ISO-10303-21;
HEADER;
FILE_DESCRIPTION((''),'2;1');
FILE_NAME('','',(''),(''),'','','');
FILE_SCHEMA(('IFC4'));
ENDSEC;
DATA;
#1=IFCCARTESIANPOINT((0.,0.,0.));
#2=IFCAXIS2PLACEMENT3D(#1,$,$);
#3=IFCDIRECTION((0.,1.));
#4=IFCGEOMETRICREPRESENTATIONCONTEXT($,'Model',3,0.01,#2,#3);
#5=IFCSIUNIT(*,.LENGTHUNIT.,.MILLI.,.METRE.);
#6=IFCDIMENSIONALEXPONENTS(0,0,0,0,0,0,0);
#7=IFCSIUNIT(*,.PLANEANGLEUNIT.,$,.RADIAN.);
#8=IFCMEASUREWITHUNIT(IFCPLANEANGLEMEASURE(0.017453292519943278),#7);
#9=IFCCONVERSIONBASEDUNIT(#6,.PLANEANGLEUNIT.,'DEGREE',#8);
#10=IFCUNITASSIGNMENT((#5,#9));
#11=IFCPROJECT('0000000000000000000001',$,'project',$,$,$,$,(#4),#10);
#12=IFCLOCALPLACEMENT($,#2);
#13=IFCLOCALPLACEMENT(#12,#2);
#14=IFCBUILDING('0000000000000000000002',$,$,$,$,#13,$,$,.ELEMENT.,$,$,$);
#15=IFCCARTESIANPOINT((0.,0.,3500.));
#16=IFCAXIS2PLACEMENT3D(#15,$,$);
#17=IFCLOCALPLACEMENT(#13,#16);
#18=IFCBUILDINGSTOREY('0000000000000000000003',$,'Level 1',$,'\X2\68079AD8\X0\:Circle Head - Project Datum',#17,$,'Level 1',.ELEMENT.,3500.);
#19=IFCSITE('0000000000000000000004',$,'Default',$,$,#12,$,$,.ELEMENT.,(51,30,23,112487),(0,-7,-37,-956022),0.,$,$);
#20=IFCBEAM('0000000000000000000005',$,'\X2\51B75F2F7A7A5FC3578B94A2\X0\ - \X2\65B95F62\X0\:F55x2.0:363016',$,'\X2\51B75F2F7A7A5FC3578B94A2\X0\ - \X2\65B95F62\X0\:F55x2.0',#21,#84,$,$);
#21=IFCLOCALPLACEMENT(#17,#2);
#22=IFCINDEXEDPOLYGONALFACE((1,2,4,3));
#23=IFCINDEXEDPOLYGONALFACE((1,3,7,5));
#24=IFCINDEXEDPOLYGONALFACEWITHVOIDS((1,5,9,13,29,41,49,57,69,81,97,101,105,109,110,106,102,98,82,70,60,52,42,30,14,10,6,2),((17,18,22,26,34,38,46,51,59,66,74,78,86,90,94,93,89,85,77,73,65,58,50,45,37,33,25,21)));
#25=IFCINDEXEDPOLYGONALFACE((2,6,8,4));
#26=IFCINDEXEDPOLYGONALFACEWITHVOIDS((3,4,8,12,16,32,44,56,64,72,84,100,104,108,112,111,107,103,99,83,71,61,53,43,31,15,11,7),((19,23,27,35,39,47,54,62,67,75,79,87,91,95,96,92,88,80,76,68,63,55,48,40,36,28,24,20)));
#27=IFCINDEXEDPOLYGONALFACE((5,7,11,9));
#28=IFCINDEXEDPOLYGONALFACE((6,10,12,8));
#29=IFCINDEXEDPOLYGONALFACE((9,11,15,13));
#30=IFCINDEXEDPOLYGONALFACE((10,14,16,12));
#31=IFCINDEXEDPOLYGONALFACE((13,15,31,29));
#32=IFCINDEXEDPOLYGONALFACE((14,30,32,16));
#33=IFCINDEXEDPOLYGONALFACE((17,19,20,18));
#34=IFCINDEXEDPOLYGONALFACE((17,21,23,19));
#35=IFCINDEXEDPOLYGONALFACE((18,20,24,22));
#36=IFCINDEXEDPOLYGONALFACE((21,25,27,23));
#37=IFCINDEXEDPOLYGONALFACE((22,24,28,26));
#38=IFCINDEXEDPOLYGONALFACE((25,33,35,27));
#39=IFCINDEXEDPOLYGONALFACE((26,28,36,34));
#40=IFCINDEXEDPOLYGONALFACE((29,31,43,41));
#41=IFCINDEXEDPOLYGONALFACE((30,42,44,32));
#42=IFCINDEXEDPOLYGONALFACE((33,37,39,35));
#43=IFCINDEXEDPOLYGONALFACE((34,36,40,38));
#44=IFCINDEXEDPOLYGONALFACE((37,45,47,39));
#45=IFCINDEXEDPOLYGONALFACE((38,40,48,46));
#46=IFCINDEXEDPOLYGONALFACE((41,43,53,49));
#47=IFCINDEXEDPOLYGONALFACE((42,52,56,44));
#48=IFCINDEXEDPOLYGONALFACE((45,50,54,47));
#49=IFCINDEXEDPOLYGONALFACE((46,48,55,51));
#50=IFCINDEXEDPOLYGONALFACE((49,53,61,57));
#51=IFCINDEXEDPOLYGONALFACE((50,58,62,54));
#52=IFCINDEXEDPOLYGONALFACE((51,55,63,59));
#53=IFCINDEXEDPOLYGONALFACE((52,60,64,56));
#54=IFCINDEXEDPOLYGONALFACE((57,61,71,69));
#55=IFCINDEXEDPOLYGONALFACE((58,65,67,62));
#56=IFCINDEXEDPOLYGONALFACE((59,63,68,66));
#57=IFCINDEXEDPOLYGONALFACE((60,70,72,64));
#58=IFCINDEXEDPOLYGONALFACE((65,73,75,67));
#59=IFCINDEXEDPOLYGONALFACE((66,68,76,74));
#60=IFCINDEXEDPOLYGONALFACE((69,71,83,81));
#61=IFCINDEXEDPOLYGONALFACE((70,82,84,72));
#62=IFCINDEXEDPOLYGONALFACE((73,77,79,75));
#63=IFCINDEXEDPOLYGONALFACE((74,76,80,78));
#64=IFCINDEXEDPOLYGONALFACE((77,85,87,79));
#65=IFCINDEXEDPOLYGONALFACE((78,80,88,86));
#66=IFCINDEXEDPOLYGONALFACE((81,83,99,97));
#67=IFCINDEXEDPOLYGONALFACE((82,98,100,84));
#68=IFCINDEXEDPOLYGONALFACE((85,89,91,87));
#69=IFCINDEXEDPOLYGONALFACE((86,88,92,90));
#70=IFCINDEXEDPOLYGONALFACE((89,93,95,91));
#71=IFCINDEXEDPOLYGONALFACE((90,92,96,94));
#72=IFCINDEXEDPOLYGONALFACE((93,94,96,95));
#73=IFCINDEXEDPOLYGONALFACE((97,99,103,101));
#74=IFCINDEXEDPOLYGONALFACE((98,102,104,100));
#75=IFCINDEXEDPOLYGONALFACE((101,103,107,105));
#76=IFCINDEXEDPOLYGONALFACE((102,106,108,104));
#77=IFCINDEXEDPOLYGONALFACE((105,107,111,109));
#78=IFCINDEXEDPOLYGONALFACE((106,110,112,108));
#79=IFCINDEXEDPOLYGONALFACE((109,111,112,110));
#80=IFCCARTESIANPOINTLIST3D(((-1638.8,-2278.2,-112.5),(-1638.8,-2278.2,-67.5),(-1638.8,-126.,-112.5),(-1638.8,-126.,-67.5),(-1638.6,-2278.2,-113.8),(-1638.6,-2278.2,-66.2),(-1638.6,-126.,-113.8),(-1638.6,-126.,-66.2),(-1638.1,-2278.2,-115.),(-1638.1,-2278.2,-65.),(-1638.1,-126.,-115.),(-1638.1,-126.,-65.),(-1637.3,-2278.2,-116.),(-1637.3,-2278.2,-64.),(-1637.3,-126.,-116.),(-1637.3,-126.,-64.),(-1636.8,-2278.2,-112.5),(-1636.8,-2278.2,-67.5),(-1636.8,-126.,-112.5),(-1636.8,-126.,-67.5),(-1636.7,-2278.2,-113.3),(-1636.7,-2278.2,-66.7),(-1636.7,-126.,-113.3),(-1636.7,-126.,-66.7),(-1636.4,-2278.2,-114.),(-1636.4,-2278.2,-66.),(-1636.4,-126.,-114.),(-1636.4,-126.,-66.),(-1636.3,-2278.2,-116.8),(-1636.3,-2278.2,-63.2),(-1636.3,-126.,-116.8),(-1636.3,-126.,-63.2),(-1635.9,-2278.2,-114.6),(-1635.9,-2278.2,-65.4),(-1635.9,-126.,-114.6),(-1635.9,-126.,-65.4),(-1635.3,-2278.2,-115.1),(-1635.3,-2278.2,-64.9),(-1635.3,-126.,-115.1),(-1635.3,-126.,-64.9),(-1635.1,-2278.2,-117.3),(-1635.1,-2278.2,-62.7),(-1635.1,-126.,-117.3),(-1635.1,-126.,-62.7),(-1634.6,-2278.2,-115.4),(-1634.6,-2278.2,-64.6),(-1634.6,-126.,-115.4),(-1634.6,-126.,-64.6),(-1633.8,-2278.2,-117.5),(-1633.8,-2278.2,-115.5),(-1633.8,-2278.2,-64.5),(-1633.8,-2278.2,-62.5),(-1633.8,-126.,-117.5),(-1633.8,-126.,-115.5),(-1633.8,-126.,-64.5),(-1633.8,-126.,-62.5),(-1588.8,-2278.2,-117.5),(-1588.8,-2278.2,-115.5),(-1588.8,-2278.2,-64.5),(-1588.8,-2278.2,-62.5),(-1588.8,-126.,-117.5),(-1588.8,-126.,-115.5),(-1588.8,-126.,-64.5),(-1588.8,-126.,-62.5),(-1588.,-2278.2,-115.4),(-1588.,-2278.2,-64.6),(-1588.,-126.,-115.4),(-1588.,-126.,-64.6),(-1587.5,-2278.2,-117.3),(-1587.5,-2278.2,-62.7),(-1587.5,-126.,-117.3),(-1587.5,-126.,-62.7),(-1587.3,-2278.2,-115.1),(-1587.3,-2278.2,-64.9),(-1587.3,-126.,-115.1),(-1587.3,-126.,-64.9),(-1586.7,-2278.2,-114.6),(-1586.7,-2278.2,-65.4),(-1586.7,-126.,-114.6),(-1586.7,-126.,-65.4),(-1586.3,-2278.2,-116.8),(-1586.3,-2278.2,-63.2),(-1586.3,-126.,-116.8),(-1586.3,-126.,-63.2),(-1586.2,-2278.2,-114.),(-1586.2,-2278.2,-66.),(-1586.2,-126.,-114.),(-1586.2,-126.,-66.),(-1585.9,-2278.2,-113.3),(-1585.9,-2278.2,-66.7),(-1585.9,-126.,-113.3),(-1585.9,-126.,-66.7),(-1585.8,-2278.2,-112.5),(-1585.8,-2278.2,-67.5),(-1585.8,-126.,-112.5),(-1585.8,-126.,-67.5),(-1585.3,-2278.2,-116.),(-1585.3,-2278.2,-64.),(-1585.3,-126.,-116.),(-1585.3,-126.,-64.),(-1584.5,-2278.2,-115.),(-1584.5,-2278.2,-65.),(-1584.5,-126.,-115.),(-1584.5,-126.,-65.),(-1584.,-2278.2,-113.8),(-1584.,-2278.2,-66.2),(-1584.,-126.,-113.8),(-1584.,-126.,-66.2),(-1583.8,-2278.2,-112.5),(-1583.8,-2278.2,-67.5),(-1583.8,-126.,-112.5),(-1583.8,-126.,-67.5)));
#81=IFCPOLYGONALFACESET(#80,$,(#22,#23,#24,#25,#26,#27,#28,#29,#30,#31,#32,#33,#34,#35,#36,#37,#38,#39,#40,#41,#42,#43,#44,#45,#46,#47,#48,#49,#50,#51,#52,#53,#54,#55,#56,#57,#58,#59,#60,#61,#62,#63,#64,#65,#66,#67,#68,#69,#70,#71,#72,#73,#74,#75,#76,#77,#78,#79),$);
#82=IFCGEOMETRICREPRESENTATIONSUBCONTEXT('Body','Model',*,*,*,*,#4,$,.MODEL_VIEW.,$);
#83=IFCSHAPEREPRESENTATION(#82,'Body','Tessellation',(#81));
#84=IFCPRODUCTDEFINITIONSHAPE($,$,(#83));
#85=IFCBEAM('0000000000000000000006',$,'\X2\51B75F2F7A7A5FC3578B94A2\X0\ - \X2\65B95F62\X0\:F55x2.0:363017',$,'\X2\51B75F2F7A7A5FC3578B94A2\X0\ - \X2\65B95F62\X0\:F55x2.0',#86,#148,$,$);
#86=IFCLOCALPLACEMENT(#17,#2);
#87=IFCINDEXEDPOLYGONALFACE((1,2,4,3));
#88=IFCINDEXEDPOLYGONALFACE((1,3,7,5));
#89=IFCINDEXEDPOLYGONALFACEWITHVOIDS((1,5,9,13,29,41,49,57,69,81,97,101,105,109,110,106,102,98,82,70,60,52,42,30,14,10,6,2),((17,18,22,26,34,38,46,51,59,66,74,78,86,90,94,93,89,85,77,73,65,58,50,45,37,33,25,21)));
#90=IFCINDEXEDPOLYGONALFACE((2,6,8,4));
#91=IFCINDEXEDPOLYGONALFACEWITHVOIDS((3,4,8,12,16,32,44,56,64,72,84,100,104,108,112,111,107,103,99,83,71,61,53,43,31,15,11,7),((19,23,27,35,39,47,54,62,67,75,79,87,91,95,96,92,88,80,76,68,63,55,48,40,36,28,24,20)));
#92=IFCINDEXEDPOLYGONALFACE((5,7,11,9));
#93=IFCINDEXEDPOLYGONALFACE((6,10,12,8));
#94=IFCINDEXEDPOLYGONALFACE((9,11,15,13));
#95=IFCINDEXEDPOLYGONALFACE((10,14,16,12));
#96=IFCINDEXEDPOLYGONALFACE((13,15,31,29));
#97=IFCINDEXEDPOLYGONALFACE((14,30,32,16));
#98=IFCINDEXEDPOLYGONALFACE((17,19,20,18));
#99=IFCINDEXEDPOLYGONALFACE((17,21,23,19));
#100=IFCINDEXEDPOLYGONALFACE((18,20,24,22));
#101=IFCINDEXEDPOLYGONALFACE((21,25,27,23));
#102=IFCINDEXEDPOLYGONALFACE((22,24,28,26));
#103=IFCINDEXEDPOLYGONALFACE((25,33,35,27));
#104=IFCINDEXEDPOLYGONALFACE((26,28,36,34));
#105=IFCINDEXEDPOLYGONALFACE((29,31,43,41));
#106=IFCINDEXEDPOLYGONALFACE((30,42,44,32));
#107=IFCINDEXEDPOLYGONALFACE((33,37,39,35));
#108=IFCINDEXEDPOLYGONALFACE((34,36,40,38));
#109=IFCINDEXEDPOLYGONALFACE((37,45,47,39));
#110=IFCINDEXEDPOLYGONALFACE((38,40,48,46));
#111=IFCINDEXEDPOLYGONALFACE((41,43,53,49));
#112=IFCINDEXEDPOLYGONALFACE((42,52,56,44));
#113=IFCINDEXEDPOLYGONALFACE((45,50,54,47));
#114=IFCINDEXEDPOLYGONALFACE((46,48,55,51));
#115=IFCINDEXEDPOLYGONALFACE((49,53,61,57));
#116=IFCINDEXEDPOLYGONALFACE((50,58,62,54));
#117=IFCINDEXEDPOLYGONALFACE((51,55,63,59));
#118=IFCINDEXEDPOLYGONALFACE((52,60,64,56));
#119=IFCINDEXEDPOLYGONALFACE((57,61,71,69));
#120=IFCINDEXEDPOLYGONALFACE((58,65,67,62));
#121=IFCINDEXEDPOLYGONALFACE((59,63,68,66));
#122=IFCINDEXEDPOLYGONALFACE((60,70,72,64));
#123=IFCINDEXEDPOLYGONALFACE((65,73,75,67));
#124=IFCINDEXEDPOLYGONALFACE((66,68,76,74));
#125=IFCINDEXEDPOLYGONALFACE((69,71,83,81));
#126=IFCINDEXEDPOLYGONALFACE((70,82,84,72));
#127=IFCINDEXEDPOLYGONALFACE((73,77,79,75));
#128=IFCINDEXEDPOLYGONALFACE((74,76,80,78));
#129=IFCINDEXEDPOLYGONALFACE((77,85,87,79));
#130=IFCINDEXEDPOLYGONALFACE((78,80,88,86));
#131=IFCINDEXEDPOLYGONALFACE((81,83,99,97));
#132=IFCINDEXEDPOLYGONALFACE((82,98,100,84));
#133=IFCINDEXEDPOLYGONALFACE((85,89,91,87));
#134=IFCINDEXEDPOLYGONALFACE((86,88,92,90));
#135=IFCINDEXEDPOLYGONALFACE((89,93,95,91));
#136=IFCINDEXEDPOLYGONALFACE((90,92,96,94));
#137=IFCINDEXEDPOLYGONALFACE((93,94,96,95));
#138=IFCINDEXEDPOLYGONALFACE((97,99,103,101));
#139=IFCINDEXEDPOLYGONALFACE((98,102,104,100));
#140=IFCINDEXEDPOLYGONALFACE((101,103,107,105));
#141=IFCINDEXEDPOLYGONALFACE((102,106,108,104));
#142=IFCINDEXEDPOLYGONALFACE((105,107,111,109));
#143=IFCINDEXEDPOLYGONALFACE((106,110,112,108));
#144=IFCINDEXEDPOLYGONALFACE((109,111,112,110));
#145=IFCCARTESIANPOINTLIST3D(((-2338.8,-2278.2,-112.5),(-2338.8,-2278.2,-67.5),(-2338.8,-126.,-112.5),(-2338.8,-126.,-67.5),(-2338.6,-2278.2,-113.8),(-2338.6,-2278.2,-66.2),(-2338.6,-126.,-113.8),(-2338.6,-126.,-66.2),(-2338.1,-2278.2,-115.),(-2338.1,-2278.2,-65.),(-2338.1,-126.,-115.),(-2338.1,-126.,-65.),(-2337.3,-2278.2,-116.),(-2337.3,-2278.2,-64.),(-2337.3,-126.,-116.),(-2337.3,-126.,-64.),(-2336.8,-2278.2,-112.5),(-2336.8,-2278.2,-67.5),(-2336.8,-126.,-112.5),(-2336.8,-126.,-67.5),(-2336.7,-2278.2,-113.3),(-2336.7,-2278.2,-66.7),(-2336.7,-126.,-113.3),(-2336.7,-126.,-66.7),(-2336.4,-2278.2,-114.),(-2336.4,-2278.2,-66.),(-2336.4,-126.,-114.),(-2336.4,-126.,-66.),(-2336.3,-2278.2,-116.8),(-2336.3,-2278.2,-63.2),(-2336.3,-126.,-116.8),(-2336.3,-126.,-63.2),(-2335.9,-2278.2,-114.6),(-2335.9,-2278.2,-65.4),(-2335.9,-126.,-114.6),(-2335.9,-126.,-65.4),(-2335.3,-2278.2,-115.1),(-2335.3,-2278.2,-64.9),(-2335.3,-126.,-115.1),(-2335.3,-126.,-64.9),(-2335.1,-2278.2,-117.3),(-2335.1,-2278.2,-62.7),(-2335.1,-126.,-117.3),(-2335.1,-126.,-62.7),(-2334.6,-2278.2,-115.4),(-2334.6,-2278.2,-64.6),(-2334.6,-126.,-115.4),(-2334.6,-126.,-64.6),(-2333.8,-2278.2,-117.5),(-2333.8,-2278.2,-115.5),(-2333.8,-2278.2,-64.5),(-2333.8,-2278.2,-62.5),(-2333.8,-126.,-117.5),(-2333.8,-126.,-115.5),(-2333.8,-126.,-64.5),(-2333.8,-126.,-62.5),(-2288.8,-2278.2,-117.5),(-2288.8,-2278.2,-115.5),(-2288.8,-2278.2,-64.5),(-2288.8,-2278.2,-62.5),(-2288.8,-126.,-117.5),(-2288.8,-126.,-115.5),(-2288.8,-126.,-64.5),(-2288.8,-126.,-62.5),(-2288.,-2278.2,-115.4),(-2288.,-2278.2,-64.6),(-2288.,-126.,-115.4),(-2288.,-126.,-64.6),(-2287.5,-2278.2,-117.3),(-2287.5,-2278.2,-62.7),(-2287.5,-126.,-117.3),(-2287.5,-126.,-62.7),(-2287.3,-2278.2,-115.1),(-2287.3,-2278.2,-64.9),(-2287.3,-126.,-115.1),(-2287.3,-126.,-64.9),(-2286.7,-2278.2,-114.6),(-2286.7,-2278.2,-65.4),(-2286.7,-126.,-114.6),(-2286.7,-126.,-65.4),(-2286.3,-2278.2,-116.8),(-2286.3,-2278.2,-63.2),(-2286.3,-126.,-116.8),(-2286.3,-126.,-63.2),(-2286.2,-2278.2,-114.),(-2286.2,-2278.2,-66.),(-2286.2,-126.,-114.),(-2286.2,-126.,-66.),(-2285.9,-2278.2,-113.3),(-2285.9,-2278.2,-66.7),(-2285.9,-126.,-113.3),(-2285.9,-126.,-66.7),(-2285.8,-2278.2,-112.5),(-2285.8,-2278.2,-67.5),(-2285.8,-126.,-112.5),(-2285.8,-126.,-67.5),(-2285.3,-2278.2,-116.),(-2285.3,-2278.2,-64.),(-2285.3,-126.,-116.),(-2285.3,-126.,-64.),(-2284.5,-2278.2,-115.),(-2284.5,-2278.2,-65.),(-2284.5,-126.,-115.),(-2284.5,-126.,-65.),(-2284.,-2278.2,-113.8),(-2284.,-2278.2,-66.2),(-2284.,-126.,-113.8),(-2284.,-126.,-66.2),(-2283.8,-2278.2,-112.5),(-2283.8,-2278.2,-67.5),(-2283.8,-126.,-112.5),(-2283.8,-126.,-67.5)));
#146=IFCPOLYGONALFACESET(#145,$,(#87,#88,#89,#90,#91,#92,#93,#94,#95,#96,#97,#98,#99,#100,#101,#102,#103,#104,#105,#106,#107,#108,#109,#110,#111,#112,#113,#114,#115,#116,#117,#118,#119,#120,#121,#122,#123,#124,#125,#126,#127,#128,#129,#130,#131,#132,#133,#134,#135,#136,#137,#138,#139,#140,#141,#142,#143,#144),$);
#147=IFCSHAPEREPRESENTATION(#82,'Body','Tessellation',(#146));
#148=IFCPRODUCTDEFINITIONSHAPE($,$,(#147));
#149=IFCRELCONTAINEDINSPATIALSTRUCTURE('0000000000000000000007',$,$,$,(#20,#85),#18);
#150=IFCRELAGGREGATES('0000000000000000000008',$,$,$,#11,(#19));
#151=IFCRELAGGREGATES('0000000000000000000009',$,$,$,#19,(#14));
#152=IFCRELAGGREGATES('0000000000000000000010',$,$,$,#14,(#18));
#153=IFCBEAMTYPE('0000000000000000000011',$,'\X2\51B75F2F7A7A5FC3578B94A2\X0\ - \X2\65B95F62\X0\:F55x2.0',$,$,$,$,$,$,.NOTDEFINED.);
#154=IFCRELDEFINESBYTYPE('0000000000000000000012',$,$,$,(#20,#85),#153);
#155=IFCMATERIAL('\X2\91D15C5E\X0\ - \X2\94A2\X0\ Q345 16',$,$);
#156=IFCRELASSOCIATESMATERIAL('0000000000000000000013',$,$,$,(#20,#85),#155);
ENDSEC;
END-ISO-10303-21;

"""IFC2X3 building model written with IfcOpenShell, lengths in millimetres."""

from ifc_helpers import new_model, entity, si_unit, converted_unit, direction, frame, frame_2d, origin, place, context, subcontext, project, spatial, polyline, circle_curve, parameter, trimmed, segment, composite_curve, outline, extrude, material, type_object, element, save


model = new_model("IFC2X3")

# Units and contexts
model_context = context("Model", 3, precision=0.01, world=origin(), true_north=direction((0.0, 1.0)))
body_context = subcontext(model_context, "Body", "Model", "MODEL_VIEW")
ifc_project = project(units=[si_unit("LENGTHUNIT", "METRE", prefix="MILLI"), converted_unit("PLANEANGLEUNIT", "DEGREE", entity("IfcPlaneAngleMeasure", 0.017453292519943278), si_unit("PLANEANGLEUNIT", "RADIAN"), dimensions=[0, 0, 0, 0, 0, 0, 0])], contexts=[model_context])

# Site, building, storey
site_placement = place(None, origin())
site = spatial("IfcSite", under=ifc_project, at=site_placement, Name="Default", CompositionType="ELEMENT", RefLatitude=(51, 30, 23, 112487), RefLongitude=(0, -7, -37, -956022), RefElevation=0.0)
building_placement = place(site_placement, origin())
building = spatial("IfcBuilding", under=site, at=building_placement, CompositionType="ELEMENT")
storey_placement = place(building_placement, frame((0.0, 0.0, 3500.0)))
storey = spatial("IfcBuildingStorey", under=building, at=storey_placement, Name="Level 1", ObjectType="标高:Circle Head - Project Datum", LongName="Level 1", CompositionType="ELEMENT", Elevation=3500.0)

# Beams
ifc_material_1 = material(Name="金属 - 钢 Q345 16")
beam_type_1 = type_object("IfcBeamType", Name="冷弯空心型钢 - 方形:F55x2.0", PredefinedType="NOTDEFINED")
beam_1_placement = place(storey_placement, frame((-1611.3, -390.5, -62.5), z_axis=(0.0, 0.0, 1.0), x_axis=(0.0, -1.0, 0.0)))
element("IfcBeam", 1, at=beam_1_placement, inside=storey, type_object=beam_type_1, material=ifc_material_1, Name="冷弯空心型钢 - 方形:F55x2.0:363016", ObjectType="冷弯空心型钢 - 方形:F55x2.0", context=body_context, shape_type="SweptSolid", body=[
    extrude(outline(composite_curve([segment(trimmed(circle_curve(frame_2d((-22.5, 22.5), x_axis=(1.0, 0.0)), 5.0), [parameter(90.0)], [parameter(180.0)], True, "PARAMETER"), True, "CONTINUOUS"), segment(polyline([(-27.5, 22.5), (-27.5, -22.5)]), True, "CONTINUOUS"), segment(trimmed(circle_curve(frame_2d((-22.5, -22.5), x_axis=(1.0, 0.0)), 5.0), [parameter(180.0)], [parameter(270.0)], True, "PARAMETER"), True, "CONTINUOUS"), segment(polyline([(-22.5, -27.5), (22.5, -27.5)]), True, "CONTINUOUS"), segment(trimmed(circle_curve(frame_2d((22.5, -22.5), x_axis=(1.0, 0.0)), 5.0), [parameter(270.0)], [parameter(0.0)], True, "PARAMETER"), True, "CONTINUOUS"), segment(polyline([(27.5, -22.5), (27.5, 22.5)]), True, "CONTINUOUS"), segment(trimmed(circle_curve(frame_2d((22.5, 22.5), x_axis=(1.0, 0.0)), 5.0), [parameter(0.0)], [parameter(90.0)], True, "PARAMETER"), True, "CONTINUOUS"), segment(polyline([(22.5, 27.5), (-22.5, 27.5)]), True, "CONTINUOUS")], self_intersect=False), holes=[composite_curve([segment(polyline([(-22.5, 25.5), (22.5, 25.5)]), True, "CONTINUOUS"), segment(trimmed(circle_curve(frame_2d((22.5, 22.5), x_axis=(1.0, 0.0)), 3.0), [parameter(0.0)], [parameter(90.0)], True, "PARAMETER"), False, "CONTINUOUS"), segment(polyline([(25.5, 22.5), (25.5, -22.5)]), True, "CONTINUOUS"), segment(trimmed(circle_curve(frame_2d((22.5, -22.5), x_axis=(1.0, 0.0)), 3.0), [parameter(270.0)], [parameter(360.0)], True, "PARAMETER"), False, "CONTINUOUS"), segment(polyline([(22.5, -25.5), (-22.5, -25.5)]), True, "CONTINUOUS"), segment(trimmed(circle_curve(frame_2d((-22.5, -22.5), x_axis=(1.0, 0.0)), 3.0), [parameter(180.0)], [parameter(270.0)], True, "PARAMETER"), False, "CONTINUOUS"), segment(polyline([(-25.5, -22.5), (-25.5, 22.5)]), True, "CONTINUOUS"), segment(trimmed(circle_curve(frame_2d((-22.5, 22.5), x_axis=(1.0, 0.0)), 3.0), [parameter(90.0)], [parameter(180.0)], True, "PARAMETER"), False, "CONTINUOUS")], self_intersect=False)]), frame((-264.5, 0.0, -27.5), z_axis=(1.0, 0.0, 0.0), x_axis=(0.0, 1.0, 0.0)), (0.0, 0.0, 1.0), 2152.2),
])
beam_2_placement = place(storey_placement, frame((-2311.3, -390.5, -62.5), z_axis=(0.0, 0.0, 1.0), x_axis=(0.0, -1.0, 0.0)))
element("IfcBeam", 2, at=beam_2_placement, inside=storey, type_object=beam_type_1, material=ifc_material_1, Name="冷弯空心型钢 - 方形:F55x2.0:363017", ObjectType="冷弯空心型钢 - 方形:F55x2.0", context=body_context, shape_type="SweptSolid", body=[
    extrude(outline(composite_curve([segment(trimmed(circle_curve(frame_2d((-22.5, 22.5), x_axis=(1.0, 0.0)), 5.0), [parameter(90.0)], [parameter(180.0)], True, "PARAMETER"), True, "CONTINUOUS"), segment(polyline([(-27.5, 22.5), (-27.5, -22.5)]), True, "CONTINUOUS"), segment(trimmed(circle_curve(frame_2d((-22.5, -22.5), x_axis=(1.0, 0.0)), 5.0), [parameter(180.0)], [parameter(270.0)], True, "PARAMETER"), True, "CONTINUOUS"), segment(polyline([(-22.5, -27.5), (22.5, -27.5)]), True, "CONTINUOUS"), segment(trimmed(circle_curve(frame_2d((22.5, -22.5), x_axis=(1.0, 0.0)), 5.0), [parameter(270.0)], [parameter(0.0)], True, "PARAMETER"), True, "CONTINUOUS"), segment(polyline([(27.5, -22.5), (27.5, 22.5)]), True, "CONTINUOUS"), segment(trimmed(circle_curve(frame_2d((22.5, 22.5), x_axis=(1.0, 0.0)), 5.0), [parameter(0.0)], [parameter(90.0)], True, "PARAMETER"), True, "CONTINUOUS"), segment(polyline([(22.5, 27.5), (-22.5, 27.5)]), True, "CONTINUOUS")], self_intersect=False), holes=[composite_curve([segment(polyline([(-22.5, 25.5), (22.5, 25.5)]), True, "CONTINUOUS"), segment(trimmed(circle_curve(frame_2d((22.5, 22.5), x_axis=(1.0, 0.0)), 3.0), [parameter(0.0)], [parameter(90.0)], True, "PARAMETER"), False, "CONTINUOUS"), segment(polyline([(25.5, 22.5), (25.5, -22.5)]), True, "CONTINUOUS"), segment(trimmed(circle_curve(frame_2d((22.5, -22.5), x_axis=(1.0, 0.0)), 3.0), [parameter(270.0)], [parameter(360.0)], True, "PARAMETER"), False, "CONTINUOUS"), segment(polyline([(22.5, -25.5), (-22.5, -25.5)]), True, "CONTINUOUS"), segment(trimmed(circle_curve(frame_2d((-22.5, -22.5), x_axis=(1.0, 0.0)), 3.0), [parameter(180.0)], [parameter(270.0)], True, "PARAMETER"), False, "CONTINUOUS"), segment(polyline([(-25.5, -22.5), (-25.5, 22.5)]), True, "CONTINUOUS"), segment(trimmed(circle_curve(frame_2d((-22.5, 22.5), x_axis=(1.0, 0.0)), 3.0), [parameter(90.0)], [parameter(180.0)], True, "PARAMETER"), False, "CONTINUOUS")], self_intersect=False)]), frame((-264.5, 0.0, -27.5), z_axis=(1.0, 0.0, 0.0), x_axis=(0.0, 1.0, 0.0)), (0.0, 0.0, 1.0), 2152.2),
])

save(model, "model.ifc")
